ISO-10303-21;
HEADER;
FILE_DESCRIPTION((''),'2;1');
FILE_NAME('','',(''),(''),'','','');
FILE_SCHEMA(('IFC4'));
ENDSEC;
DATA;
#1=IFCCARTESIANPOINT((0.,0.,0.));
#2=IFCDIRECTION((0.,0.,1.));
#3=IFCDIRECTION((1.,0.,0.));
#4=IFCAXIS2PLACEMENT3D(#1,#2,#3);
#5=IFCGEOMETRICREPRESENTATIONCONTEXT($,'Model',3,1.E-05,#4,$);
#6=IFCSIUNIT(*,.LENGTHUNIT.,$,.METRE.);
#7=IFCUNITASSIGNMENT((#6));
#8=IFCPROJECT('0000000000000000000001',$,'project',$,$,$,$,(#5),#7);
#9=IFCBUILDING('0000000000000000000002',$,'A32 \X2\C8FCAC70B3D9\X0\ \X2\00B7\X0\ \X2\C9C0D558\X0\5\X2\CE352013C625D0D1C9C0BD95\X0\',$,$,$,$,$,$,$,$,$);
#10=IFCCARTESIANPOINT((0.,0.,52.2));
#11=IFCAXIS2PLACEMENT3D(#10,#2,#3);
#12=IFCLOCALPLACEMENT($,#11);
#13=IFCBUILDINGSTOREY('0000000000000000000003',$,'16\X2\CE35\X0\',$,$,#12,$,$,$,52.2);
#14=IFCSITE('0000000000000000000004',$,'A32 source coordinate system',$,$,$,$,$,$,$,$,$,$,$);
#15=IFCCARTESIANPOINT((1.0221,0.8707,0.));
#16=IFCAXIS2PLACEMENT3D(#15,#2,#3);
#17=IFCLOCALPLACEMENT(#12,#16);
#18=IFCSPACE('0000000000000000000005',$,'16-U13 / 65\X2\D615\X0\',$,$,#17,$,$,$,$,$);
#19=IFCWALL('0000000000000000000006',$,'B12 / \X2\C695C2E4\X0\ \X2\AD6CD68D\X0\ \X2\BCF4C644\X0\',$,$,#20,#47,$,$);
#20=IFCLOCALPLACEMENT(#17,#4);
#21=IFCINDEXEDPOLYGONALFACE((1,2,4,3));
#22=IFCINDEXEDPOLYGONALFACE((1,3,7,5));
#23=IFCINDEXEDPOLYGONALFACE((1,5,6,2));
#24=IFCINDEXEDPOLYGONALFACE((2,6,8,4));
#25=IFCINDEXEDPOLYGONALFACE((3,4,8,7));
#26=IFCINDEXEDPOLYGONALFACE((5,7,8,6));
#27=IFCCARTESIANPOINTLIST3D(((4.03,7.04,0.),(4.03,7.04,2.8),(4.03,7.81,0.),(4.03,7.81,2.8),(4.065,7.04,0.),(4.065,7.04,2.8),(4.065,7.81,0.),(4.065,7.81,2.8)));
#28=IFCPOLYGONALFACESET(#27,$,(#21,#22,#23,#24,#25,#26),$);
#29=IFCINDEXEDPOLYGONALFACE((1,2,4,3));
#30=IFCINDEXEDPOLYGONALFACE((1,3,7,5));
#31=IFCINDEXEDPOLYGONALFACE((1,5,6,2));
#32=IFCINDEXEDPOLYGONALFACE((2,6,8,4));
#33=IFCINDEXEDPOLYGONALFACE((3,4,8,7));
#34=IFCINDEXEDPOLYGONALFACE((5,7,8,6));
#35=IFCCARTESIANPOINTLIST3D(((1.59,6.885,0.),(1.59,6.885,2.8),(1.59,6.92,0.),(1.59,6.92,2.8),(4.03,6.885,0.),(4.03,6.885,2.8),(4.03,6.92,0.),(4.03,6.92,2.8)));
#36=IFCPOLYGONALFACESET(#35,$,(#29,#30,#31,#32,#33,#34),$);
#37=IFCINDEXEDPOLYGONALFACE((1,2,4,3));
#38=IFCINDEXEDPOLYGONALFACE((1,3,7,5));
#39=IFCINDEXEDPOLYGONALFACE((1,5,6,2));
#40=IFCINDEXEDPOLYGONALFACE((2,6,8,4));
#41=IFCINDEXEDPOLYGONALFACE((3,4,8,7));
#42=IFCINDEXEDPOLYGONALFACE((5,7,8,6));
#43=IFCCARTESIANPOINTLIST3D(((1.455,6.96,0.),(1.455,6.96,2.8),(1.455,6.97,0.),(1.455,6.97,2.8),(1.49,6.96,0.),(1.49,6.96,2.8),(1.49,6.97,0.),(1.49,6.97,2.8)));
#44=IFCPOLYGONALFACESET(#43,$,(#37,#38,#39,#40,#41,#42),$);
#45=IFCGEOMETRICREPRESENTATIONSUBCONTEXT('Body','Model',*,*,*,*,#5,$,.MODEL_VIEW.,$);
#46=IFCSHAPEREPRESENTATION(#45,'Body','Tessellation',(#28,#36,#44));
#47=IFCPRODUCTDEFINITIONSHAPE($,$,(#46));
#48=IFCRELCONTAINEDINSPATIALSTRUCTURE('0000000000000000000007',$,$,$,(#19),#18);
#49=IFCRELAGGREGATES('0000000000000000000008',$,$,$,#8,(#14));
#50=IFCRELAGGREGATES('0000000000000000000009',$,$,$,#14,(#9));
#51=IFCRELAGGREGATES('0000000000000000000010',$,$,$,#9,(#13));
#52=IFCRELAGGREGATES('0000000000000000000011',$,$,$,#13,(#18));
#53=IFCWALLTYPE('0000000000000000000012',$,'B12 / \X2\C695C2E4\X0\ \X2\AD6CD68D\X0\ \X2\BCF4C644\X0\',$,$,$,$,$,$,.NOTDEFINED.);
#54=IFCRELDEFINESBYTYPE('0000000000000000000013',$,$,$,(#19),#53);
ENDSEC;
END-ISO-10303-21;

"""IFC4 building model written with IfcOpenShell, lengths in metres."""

from ifc_helpers import new_model, si_unit, frame, origin, origin_with_axes, place, context, subcontext, project, spatial, polyline, outline, extrude, source, transform, mapped, type_object, type_shapes, element, save


model = new_model("IFC4")

# Units and contexts
model_context = context("Model", 3, precision=1e-05, world=origin_with_axes())
body_context = subcontext(model_context, "Body", "Model", "MODEL_VIEW")
ifc_project = project(units=[si_unit("LENGTHUNIT", "METRE")], contexts=[model_context])

# Site, building, storey, space
storey_placement = place(None, frame((0.0, 0.0, 52.2), z_axis=(0.0, 0.0, 1.0), x_axis=(1.0, 0.0, 0.0)))
space_placement = place(storey_placement, frame((1.0221, 0.8707, 0.0), z_axis=(0.0, 0.0, 1.0), x_axis=(1.0, 0.0, 0.0)))
site = spatial("IfcSite", under=ifc_project, Name="A32 source coordinate system")
building = spatial("IfcBuilding", under=site, Name="A32 주거동 · 지하5층–옥탑지붕")
storey = spatial("IfcBuildingStorey", under=building, at=storey_placement, Name="16층", Elevation=52.2)
space = spatial("IfcSpace", under=storey, at=space_placement, Name="16-U13 / 65형")

# Wall
wall_type_1 = type_object("IfcWallType", Name="B12 / 욕실 구획 보완", PredefinedType="NOTDEFINED")
shared_shape_1 = source(origin(), body_context, "Body", "SweptSolid", [
    extrude(outline(polyline([(4.065, 7.04), (4.03, 7.04), (4.03, 7.81), (4.065, 7.81), (4.065, 7.04)])), origin(), (0.0, 0.0, 1.0), 2.8),
    extrude(outline(polyline([(1.59, 6.92), (4.03, 6.92), (4.03, 6.885), (1.59, 6.885), (1.59, 6.92)])), origin(), (0.0, 0.0, 1.0), 2.8),
    extrude(outline(polyline([(1.455, 6.97), (1.49, 6.97), (1.49, 6.96), (1.455, 6.96), (1.455, 6.97)])), origin(), (0.0, 0.0, 1.0), 2.8),
])
type_shapes(wall_type_1, [shared_shape_1])
wall_1_placement = place(space_placement, origin_with_axes())
element("IfcWall", 1, at=wall_1_placement, inside=space, type_object=wall_type_1, Name="B12 / 욕실 구획 보완", context=body_context, shape_type="MappedRepresentation", body=[
    mapped(shared_shape_1, transform((0.0, 0.0, 0.0), scale=1.0)),
])

save(model, "model.ifc")
